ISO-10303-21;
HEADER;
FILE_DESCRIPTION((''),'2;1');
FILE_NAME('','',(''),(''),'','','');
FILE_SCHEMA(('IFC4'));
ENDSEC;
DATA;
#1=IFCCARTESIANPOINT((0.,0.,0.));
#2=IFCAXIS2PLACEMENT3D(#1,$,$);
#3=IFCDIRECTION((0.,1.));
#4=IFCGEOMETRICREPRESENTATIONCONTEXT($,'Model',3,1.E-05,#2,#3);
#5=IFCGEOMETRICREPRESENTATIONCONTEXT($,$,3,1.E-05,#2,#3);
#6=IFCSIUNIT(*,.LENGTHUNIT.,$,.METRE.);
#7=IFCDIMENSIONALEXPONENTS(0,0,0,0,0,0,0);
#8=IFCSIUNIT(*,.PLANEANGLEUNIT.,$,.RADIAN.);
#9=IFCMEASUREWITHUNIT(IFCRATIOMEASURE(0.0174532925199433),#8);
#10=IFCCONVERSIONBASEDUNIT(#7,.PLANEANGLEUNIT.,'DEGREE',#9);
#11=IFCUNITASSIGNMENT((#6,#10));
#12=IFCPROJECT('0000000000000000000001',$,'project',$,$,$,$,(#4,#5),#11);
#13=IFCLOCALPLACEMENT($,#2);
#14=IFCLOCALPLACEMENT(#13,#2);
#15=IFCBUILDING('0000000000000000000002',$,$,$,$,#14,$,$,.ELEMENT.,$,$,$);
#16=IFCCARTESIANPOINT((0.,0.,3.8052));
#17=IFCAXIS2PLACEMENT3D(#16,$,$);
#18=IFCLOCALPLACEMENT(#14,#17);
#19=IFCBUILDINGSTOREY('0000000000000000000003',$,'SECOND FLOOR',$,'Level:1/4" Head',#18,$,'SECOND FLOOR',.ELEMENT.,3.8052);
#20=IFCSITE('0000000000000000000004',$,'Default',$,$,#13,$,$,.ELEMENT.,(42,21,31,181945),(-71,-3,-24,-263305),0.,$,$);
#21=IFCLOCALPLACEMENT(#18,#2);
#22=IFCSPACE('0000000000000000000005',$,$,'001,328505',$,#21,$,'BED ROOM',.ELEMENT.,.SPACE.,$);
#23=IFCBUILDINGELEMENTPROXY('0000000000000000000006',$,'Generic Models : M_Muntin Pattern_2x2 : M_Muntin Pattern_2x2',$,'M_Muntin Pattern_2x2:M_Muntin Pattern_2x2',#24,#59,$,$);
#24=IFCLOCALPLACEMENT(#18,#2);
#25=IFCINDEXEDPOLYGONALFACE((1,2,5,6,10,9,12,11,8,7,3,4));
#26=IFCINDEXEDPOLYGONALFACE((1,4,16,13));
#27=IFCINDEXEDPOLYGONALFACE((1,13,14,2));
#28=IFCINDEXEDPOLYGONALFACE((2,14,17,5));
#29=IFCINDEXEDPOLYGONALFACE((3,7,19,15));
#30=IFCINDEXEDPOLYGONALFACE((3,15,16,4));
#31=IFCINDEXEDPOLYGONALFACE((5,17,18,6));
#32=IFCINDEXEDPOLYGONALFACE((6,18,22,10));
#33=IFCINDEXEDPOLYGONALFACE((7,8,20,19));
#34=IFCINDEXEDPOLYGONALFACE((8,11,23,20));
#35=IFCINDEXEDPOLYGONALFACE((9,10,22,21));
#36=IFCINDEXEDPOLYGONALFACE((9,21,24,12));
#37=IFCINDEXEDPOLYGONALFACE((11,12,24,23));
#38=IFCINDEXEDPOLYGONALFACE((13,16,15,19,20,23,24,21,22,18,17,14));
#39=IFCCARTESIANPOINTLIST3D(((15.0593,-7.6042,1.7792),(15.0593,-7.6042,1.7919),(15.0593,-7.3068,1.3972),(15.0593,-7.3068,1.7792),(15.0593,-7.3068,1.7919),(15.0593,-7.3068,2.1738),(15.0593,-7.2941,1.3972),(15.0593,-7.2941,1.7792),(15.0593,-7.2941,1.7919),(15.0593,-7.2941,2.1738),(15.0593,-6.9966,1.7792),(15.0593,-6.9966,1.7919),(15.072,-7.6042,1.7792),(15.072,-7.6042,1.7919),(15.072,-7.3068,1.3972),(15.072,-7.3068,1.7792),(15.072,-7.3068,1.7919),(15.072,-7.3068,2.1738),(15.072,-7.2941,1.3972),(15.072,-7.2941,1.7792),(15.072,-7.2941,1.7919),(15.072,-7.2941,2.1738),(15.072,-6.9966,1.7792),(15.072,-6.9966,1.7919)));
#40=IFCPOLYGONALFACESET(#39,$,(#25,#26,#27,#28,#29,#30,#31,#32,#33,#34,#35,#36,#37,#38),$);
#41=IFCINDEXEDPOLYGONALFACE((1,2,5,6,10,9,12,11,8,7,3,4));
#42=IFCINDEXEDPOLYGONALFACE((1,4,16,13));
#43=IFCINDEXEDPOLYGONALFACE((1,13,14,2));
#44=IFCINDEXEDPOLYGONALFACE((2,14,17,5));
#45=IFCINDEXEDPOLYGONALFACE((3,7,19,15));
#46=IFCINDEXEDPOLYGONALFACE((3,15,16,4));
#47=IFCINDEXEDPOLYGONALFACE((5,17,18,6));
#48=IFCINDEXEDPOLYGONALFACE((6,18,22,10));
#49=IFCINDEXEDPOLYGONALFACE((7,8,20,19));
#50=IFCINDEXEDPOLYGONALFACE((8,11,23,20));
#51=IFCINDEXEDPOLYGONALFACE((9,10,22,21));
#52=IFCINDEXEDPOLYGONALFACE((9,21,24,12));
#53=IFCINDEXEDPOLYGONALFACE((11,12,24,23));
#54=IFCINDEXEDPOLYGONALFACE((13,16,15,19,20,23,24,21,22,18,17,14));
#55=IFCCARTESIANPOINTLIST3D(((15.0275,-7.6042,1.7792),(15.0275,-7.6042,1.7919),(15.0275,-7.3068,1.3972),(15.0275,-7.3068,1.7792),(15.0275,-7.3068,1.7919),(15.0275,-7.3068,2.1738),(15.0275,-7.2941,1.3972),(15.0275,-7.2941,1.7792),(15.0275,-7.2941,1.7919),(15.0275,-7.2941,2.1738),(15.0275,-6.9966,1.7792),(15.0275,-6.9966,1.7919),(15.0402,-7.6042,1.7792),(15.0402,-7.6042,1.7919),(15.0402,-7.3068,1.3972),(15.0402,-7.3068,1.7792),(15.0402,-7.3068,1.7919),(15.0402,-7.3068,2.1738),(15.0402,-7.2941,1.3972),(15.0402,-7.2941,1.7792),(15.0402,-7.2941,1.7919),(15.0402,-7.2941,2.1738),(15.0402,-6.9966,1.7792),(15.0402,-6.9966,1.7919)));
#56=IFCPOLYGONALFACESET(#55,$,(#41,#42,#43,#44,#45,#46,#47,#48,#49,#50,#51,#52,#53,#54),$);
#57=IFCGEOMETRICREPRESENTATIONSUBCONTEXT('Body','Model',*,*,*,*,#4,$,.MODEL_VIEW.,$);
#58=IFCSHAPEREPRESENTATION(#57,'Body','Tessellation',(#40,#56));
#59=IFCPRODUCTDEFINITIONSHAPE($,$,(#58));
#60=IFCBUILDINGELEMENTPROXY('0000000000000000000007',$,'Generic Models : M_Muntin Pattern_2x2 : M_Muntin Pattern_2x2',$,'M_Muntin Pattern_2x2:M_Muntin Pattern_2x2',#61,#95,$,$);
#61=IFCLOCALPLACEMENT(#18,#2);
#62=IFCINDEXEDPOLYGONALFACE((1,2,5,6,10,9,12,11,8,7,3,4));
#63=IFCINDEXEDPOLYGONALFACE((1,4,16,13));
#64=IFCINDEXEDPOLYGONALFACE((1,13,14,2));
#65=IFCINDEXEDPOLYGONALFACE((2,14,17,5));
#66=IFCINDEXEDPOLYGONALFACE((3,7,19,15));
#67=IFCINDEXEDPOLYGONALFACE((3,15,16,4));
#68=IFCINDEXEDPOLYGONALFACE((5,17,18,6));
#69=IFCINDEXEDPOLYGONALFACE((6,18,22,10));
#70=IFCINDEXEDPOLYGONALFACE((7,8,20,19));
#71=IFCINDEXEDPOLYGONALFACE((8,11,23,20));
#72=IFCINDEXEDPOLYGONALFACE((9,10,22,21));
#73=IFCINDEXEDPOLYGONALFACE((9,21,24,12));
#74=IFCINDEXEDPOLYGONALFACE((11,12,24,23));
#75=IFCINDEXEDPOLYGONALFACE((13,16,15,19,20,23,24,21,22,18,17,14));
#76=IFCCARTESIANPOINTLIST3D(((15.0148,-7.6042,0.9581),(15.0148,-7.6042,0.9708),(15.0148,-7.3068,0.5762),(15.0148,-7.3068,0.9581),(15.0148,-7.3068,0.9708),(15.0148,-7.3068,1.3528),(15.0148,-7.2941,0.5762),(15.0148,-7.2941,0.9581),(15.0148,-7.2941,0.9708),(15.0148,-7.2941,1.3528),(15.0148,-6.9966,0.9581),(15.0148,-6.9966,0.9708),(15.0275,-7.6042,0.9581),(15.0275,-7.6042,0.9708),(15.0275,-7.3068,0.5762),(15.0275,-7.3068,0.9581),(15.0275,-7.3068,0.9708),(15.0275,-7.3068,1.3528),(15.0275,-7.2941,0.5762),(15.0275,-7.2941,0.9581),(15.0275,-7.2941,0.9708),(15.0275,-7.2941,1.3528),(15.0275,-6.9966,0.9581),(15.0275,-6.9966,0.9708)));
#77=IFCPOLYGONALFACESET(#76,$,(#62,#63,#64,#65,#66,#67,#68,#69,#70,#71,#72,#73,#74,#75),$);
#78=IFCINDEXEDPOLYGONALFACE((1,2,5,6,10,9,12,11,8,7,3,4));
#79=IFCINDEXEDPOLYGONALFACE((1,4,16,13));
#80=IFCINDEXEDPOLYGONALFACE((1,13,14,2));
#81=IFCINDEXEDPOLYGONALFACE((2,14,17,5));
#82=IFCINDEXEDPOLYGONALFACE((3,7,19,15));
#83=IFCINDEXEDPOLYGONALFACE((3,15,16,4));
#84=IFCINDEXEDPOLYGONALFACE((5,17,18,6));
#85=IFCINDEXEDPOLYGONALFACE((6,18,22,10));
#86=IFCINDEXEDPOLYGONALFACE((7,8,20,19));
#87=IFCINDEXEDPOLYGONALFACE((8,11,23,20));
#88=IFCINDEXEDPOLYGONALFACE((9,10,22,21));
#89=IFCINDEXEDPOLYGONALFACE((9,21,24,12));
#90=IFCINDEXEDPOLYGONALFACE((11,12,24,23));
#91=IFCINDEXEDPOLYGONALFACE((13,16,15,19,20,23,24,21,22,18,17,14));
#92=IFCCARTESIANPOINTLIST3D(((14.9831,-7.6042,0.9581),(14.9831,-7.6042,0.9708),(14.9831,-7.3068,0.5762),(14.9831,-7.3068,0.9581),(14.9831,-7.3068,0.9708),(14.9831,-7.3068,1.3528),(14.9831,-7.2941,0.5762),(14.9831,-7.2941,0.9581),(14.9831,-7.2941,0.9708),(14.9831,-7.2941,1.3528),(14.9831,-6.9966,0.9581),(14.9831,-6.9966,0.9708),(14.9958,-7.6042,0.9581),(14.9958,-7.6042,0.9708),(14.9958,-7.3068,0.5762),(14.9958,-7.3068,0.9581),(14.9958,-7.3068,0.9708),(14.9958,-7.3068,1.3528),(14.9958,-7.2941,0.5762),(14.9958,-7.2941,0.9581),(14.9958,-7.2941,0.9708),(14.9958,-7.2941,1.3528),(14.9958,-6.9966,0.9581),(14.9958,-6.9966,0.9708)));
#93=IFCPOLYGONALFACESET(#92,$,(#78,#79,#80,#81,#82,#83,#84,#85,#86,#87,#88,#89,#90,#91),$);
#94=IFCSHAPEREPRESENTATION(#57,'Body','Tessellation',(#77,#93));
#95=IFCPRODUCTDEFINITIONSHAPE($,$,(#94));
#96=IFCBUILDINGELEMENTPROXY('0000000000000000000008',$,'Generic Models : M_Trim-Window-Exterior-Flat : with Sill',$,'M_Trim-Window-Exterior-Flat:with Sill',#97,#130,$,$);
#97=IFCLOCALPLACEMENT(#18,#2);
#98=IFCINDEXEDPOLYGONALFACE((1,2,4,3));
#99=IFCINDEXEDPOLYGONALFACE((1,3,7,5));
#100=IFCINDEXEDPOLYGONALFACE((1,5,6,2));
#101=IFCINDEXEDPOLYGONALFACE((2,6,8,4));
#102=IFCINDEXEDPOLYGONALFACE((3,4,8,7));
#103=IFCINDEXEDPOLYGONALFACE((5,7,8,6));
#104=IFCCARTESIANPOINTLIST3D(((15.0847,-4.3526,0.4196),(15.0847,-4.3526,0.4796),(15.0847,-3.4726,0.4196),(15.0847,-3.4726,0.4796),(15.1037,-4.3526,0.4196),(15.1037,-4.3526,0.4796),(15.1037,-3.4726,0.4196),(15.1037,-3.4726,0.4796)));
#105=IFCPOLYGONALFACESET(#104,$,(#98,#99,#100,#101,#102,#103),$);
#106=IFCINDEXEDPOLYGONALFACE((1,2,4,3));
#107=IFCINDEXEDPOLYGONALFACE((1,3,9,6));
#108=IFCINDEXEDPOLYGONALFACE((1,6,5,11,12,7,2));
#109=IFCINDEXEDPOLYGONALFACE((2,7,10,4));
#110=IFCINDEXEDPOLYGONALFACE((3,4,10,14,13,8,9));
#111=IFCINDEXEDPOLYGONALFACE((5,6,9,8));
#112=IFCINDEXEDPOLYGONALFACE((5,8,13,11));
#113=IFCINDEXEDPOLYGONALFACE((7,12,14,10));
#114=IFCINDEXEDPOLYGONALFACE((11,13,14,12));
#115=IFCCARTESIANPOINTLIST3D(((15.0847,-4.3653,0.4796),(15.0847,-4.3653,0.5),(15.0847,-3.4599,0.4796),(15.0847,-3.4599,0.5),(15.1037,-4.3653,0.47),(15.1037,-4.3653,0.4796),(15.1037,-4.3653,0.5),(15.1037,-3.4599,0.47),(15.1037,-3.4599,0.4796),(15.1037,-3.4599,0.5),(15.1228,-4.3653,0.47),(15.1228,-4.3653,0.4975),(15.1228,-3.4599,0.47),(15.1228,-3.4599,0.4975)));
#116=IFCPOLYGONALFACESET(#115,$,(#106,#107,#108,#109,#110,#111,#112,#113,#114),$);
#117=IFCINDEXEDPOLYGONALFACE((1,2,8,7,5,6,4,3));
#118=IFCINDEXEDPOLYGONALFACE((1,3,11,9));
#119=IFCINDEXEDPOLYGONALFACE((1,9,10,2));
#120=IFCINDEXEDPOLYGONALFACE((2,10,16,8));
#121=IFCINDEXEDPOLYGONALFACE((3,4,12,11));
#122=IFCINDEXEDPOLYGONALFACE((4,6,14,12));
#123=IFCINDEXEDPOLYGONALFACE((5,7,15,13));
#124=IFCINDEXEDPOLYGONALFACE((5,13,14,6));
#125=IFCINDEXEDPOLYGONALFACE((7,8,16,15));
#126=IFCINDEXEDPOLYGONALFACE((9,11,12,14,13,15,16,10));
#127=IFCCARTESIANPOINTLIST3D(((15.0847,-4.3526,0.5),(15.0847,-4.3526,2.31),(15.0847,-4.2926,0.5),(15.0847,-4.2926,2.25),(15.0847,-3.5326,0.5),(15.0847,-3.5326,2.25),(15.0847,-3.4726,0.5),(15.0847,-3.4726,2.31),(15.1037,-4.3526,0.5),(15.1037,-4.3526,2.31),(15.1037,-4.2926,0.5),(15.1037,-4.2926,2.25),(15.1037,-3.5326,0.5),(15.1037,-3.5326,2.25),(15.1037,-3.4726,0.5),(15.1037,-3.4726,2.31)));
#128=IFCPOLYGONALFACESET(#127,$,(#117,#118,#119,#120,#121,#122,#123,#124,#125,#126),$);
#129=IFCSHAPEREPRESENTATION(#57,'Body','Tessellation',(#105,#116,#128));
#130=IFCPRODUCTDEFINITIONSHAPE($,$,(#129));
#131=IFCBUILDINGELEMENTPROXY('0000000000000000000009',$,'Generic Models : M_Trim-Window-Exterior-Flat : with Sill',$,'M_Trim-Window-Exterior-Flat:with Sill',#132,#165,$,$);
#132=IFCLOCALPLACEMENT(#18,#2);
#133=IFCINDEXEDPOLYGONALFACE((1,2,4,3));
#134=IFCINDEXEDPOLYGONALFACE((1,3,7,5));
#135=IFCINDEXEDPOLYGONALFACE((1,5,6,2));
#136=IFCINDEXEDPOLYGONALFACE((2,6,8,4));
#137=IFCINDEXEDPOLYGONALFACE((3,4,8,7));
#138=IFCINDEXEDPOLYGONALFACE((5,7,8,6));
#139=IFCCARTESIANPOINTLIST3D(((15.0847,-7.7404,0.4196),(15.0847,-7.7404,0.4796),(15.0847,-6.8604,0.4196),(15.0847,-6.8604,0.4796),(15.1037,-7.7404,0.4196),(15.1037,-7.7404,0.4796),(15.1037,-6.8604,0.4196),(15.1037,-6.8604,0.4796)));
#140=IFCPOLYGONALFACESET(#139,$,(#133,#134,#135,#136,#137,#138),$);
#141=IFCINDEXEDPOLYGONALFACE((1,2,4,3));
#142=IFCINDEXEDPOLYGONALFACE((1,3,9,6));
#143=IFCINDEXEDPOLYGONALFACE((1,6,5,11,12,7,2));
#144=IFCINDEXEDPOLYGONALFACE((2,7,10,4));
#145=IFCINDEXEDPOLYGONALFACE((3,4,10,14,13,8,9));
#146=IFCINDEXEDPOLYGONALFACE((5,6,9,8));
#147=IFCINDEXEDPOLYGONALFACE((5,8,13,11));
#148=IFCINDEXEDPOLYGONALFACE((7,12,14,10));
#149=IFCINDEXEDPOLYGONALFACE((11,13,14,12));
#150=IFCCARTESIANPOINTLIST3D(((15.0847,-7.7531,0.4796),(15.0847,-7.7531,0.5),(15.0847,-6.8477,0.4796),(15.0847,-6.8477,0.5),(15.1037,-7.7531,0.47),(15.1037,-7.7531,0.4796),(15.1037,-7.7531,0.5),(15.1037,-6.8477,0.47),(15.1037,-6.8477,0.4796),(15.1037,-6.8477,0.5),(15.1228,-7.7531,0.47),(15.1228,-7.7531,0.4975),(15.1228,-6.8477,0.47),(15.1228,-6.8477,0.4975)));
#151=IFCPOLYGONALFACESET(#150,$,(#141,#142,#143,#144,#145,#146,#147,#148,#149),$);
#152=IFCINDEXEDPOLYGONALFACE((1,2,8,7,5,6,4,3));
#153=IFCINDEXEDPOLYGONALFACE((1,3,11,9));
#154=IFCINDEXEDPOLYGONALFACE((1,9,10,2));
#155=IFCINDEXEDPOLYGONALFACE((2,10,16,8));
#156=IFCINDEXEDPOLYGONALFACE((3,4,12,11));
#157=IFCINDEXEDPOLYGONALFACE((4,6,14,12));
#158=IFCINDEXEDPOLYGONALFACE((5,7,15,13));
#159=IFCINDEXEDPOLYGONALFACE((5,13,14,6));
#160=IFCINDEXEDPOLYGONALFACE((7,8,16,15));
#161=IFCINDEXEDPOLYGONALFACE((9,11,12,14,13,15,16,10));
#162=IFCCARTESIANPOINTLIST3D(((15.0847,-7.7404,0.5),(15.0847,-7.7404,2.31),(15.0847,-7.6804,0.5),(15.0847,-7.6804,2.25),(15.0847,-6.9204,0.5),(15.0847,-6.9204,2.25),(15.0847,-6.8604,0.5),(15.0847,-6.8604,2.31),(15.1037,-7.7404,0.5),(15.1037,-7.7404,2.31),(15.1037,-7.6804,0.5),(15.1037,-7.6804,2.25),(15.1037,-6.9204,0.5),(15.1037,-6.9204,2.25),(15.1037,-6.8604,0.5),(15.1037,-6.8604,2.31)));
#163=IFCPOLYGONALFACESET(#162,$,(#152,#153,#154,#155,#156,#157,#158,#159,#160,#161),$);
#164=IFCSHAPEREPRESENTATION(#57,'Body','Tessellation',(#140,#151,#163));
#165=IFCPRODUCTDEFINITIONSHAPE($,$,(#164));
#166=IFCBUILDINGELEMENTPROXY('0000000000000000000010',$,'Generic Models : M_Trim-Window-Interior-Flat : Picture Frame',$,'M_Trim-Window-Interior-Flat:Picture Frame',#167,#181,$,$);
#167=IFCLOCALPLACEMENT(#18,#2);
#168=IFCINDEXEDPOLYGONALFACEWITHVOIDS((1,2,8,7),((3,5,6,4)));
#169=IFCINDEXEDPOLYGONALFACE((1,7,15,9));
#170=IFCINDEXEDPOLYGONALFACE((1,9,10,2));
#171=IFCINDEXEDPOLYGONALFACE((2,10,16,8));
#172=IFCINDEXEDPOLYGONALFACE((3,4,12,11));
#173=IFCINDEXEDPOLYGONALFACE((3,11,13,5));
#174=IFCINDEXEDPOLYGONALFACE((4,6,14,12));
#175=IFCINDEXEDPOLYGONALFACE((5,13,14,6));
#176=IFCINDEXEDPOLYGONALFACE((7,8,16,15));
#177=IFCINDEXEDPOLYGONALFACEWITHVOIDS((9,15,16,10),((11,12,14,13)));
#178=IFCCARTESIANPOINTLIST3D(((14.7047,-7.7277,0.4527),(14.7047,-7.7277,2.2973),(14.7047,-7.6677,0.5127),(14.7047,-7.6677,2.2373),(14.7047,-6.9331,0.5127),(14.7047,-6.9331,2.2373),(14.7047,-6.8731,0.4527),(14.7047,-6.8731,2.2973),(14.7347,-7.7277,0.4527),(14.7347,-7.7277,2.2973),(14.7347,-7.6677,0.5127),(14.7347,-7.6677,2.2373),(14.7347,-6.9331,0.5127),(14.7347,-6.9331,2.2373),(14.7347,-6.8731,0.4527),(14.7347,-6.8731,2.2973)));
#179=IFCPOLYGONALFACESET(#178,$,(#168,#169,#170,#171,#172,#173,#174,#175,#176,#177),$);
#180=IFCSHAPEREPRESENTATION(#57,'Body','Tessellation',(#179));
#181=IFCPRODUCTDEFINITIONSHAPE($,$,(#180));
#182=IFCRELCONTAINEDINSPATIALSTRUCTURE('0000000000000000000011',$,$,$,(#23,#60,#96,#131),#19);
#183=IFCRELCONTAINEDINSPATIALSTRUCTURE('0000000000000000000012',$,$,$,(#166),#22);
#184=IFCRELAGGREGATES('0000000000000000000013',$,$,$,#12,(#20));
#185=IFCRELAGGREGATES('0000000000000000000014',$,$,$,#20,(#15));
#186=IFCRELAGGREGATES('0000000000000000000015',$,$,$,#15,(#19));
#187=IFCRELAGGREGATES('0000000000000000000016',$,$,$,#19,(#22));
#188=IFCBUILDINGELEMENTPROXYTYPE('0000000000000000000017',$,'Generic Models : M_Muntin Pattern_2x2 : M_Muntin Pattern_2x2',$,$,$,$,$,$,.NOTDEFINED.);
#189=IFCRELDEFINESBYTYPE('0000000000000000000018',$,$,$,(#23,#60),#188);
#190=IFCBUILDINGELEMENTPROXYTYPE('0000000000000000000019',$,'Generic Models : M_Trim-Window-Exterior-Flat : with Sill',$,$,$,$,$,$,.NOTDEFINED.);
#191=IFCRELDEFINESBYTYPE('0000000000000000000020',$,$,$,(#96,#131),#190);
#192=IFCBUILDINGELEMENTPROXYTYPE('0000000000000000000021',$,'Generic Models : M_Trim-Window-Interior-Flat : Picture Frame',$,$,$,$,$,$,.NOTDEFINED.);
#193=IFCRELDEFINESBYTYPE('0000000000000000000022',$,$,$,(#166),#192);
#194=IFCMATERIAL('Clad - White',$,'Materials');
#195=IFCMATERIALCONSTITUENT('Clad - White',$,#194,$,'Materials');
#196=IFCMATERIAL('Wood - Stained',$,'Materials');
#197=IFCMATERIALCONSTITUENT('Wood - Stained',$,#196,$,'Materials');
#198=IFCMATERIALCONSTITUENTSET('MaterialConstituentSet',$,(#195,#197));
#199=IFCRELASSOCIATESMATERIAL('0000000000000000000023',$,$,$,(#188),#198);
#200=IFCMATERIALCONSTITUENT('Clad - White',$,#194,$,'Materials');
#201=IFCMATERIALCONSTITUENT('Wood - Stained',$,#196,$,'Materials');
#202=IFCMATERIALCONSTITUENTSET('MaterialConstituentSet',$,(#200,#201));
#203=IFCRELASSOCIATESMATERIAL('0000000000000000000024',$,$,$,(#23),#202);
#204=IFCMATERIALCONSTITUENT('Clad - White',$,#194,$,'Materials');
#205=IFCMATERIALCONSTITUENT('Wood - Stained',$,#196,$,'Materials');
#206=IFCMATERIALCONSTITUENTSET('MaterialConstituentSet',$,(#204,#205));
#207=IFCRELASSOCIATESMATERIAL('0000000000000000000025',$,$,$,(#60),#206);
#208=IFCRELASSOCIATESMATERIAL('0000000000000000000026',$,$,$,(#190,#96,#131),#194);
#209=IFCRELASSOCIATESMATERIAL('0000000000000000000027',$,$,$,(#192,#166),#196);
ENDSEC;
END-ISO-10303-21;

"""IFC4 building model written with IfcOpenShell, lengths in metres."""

from ifc_helpers import new_model, entity, si_unit, converted_unit, direction, frame, origin, origin_2d_with_axis, place, context, subcontext, project, spatial, polyline, rectangle, outline, extrude, source, transform, mapped, material, constituent, constituent_set, type_object, type_shapes, element, save


model = new_model("IFC4")

# Units and contexts
model_context = context("Model", 3, precision=1e-05, world=origin(), true_north=direction((0.0, 1.0)))
context_of_model = context(None, 3, precision=1e-05, world=origin(), true_north=direction((0.0, 1.0)))
body_context = subcontext(model_context, "Body", "Model", "MODEL_VIEW")
ifc_project = project(units=[si_unit("LENGTHUNIT", "METRE"), converted_unit("PLANEANGLEUNIT", "DEGREE", entity("IfcRatioMeasure", 0.0174532925199433), si_unit("PLANEANGLEUNIT", "RADIAN"), dimensions=[0, 0, 0, 0, 0, 0, 0])], contexts=[model_context, context_of_model])

# Site, building, storey
site_placement = place(None, origin())
site = spatial("IfcSite", under=ifc_project, at=site_placement, Name="Default", CompositionType="ELEMENT", RefLatitude=(42, 21, 31, 181945), RefLongitude=(-71, -3, -24, -263305), RefElevation=0.0)
building_placement = place(site_placement, origin())
building = spatial("IfcBuilding", under=site, at=building_placement, CompositionType="ELEMENT")
storey_placement = place(building_placement, frame((0.0, 0.0, 3.8052)))
storey = spatial("IfcBuildingStorey", under=building, at=storey_placement, Name="SECOND FLOOR", ObjectType="Level:1/4\" Head", LongName="SECOND FLOOR", CompositionType="ELEMENT", Elevation=3.8052)

# Building element proxies
ifc_material_1 = material(Name="Clad - White", Category="Materials")
ifc_constituent_1 = constituent(ifc_material_1, Name="Clad - White", Category="Materials")
ifc_material_2 = material(Name="Wood - Stained", Category="Materials")
ifc_constituent_2 = constituent(ifc_material_2, Name="Wood - Stained", Category="Materials")
ifc_constituent_set_1 = constituent_set(constituents=[ifc_constituent_1, ifc_constituent_2], Name="MaterialConstituentSet")
ifc_constituent_3 = constituent(ifc_material_1, Name="Clad - White", Category="Materials")
ifc_constituent_4 = constituent(ifc_material_2, Name="Wood - Stained", Category="Materials")
ifc_constituent_set_2 = constituent_set(constituents=[ifc_constituent_3, ifc_constituent_4], Name="MaterialConstituentSet")
building_element_proxy_type_1 = type_object("IfcBuildingElementProxyType", Name="Generic Models : M_Muntin Pattern_2x2 : M_Muntin Pattern_2x2", PredefinedType="NOTDEFINED", material=ifc_constituent_set_2)
shared_shape_1 = source(origin(), body_context, "Body", "SweptSolid", [
    extrude(outline(polyline([(0.0064, -0.0064), (0.3883, -0.0064), (0.3883, 0.0063), (0.0064, 0.0063), (0.0064, 0.3038), (-0.0063, 0.3038), (-0.0063, 0.0063), (-0.3883, 0.0063), (-0.3883, -0.0064), (-0.0063, -0.0064), (-0.0063, -0.3038), (0.0064, -0.3038), (0.0064, -0.0064)])), frame((0.0, 0.0095, 0.3883), z_axis=(0.0, 1.0, 0.0), x_axis=(0.0, 0.0, 1.0)), (0.0, 0.0, 1.0), 0.0127),
    extrude(outline(polyline([(0.0064, -0.0064), (0.3883, -0.0064), (0.3883, 0.0063), (0.0064, 0.0063), (0.0064, 0.3038), (-0.0063, 0.3038), (-0.0063, 0.0063), (-0.3883, 0.0063), (-0.3883, -0.0064), (-0.0063, -0.0064), (-0.0063, -0.3038), (0.0064, -0.3038), (0.0064, -0.0064)])), frame((0.0, -0.0222, 0.3883), z_axis=(0.0, 1.0, 0.0), x_axis=(0.0, 0.0, 1.0)), (0.0, 0.0, 1.0), 0.0127),
])
type_shapes(building_element_proxy_type_1, [shared_shape_1])
proxy_1_placement = place(storey_placement, frame((15.0498, -7.3004, 1.3972), z_axis=(0.0, 0.0, 1.0), x_axis=(0.0, -1.0, 0.0)))
element("IfcBuildingElementProxy", 1, at=proxy_1_placement, inside=storey, type_object=building_element_proxy_type_1, material=ifc_constituent_set_1, Name="Generic Models : M_Muntin Pattern_2x2 : M_Muntin Pattern_2x2", ObjectType="M_Muntin Pattern_2x2:M_Muntin Pattern_2x2", context=body_context, shape_type="MappedRepresentation", body=[
    mapped(shared_shape_1, transform((0.0, 0.0, 0.0), scale=1.0)),
])
ifc_constituent_5 = constituent(ifc_material_1, Name="Clad - White", Category="Materials")
ifc_constituent_6 = constituent(ifc_material_2, Name="Wood - Stained", Category="Materials")
ifc_constituent_set_3 = constituent_set(constituents=[ifc_constituent_5, ifc_constituent_6], Name="MaterialConstituentSet")
proxy_2_placement = place(storey_placement, frame((15.0053, -7.3004, 0.5762), z_axis=(0.0, 0.0, 1.0), x_axis=(0.0, -1.0, 0.0)))
element("IfcBuildingElementProxy", 2, at=proxy_2_placement, inside=storey, type_object=building_element_proxy_type_1, material=ifc_constituent_set_3, Name="Generic Models : M_Muntin Pattern_2x2 : M_Muntin Pattern_2x2", ObjectType="M_Muntin Pattern_2x2:M_Muntin Pattern_2x2", context=body_context, shape_type="MappedRepresentation", body=[
    mapped(shared_shape_1, transform((0.0, 0.0, 0.0), scale=1.0)),
])
building_element_proxy_type_2 = type_object("IfcBuildingElementProxyType", Name="Generic Models : M_Trim-Window-Exterior-Flat : with Sill", PredefinedType="NOTDEFINED", material=ifc_material_1)
shared_shape_2 = source(origin(), body_context, "Body", "SweptSolid", [
    extrude(rectangle(XDim=0.88, YDim=0.06, at=origin_2d_with_axis()), frame((0.0, -1.8004, 0.0), z_axis=(0.0, 0.0, 1.0), x_axis=(-1.0, 0.0, 0.0)), (0.0, 0.0, 1.0), 0.0191),
    extrude(outline(polyline([(-0.019, -0.0152), (0.0, -0.0152), (0.0, -0.0057), (0.019, -0.0057), (0.019, 0.0148), (0.0, 0.0148), (-0.019, 0.0123), (-0.019, -0.0152)])), frame((-0.4527, -1.7648, 0.019), z_axis=(1.0, 0.0, 0.0), x_axis=(0.0, 0.0, -1.0)), (0.0, 0.0, 1.0), 0.9054),
    extrude(outline(polyline([(-0.92, -0.44), (0.89, -0.44), (0.89, -0.38), (-0.86, -0.38), (-0.86, 0.38), (0.89, 0.38), (0.89, 0.44), (-0.92, 0.44), (-0.92, -0.44)])), frame((0.0, -0.86, 0.0), z_axis=(0.0, 0.0, 1.0), x_axis=(0.0, -1.0, 0.0)), (0.0, 0.0, 1.0), 0.0191),
])
type_shapes(building_element_proxy_type_2, [shared_shape_2])
for number, where, z_axis, x_axis, name in (
    (3, (15.0847, -3.9126, 2.25), (1.0, 0.0, 0.0), (0.0, 1.0, 0.0), "Generic Models : M_Trim-Window-Exterior-Flat : with Sill"),
    (4, (15.0847, -7.3004, 2.25), (1.0, 0.0, 0.0), (0.0, 1.0, 0.0), "Generic Models : M_Trim-Window-Exterior-Flat : with Sill"),
):
    element("IfcBuildingElementProxy", number, at=place(storey_placement, frame(where, z_axis=z_axis, x_axis=x_axis)), inside=storey, type_object=building_element_proxy_type_2, material=ifc_material_1, Name=name, ObjectType="M_Trim-Window-Exterior-Flat:with Sill", context=body_context, shape_type="MappedRepresentation", body=[
        mapped(shared_shape_2, transform((0.0, 0.0, 0.0), scale=1.0)),
    ])

# Shared definitions
space_placement = place(storey_placement, origin())
space = spatial("IfcSpace", under=storey, at=space_placement, Description="001,328505", LongName="BED ROOM", CompositionType="ELEMENT", PredefinedType="SPACE")

# Building element proxy
building_element_proxy_type_3 = type_object("IfcBuildingElementProxyType", Name="Generic Models : M_Trim-Window-Interior-Flat : Picture Frame", PredefinedType="NOTDEFINED", material=ifc_material_2)
shared_shape_3 = source(origin(), body_context, "Body", "SweptSolid", [
    extrude(outline(polyline([(-0.4273, -0.9223), (0.4273, -0.9223), (0.4273, 0.9223), (-0.4273, 0.9223), (-0.4273, -0.9223)]), holes=[polyline([(-0.3673, -0.8623), (-0.3673, 0.8623), (0.3673, 0.8623), (0.3673, -0.8623), (-0.3673, -0.8623)])]), frame((0.0, -0.875, 0.0), z_axis=(0.0, 0.0, 1.0), x_axis=(-1.0, 0.0, 0.0)), (0.0, 0.0, 1.0), 0.03),
])
type_shapes(building_element_proxy_type_3, [shared_shape_3])
for number, where, z_axis, x_axis, name in (
    (5, (14.7347, -7.3004, 2.25), (-1.0, 0.0, 0.0), (0.0, -1.0, 0.0), "Generic Models : M_Trim-Window-Interior-Flat : Picture Frame"),
):
    element("IfcBuildingElementProxy", number, at=place(space_placement, frame(where, z_axis=z_axis, x_axis=x_axis)), inside=space, type_object=building_element_proxy_type_3, material=ifc_material_2, Name=name, ObjectType="M_Trim-Window-Interior-Flat:Picture Frame", context=body_context, shape_type="MappedRepresentation", body=[
        mapped(shared_shape_3, transform((0.0, 0.0, 0.0), scale=1.0)),
    ])

save(model, "model.ifc")
